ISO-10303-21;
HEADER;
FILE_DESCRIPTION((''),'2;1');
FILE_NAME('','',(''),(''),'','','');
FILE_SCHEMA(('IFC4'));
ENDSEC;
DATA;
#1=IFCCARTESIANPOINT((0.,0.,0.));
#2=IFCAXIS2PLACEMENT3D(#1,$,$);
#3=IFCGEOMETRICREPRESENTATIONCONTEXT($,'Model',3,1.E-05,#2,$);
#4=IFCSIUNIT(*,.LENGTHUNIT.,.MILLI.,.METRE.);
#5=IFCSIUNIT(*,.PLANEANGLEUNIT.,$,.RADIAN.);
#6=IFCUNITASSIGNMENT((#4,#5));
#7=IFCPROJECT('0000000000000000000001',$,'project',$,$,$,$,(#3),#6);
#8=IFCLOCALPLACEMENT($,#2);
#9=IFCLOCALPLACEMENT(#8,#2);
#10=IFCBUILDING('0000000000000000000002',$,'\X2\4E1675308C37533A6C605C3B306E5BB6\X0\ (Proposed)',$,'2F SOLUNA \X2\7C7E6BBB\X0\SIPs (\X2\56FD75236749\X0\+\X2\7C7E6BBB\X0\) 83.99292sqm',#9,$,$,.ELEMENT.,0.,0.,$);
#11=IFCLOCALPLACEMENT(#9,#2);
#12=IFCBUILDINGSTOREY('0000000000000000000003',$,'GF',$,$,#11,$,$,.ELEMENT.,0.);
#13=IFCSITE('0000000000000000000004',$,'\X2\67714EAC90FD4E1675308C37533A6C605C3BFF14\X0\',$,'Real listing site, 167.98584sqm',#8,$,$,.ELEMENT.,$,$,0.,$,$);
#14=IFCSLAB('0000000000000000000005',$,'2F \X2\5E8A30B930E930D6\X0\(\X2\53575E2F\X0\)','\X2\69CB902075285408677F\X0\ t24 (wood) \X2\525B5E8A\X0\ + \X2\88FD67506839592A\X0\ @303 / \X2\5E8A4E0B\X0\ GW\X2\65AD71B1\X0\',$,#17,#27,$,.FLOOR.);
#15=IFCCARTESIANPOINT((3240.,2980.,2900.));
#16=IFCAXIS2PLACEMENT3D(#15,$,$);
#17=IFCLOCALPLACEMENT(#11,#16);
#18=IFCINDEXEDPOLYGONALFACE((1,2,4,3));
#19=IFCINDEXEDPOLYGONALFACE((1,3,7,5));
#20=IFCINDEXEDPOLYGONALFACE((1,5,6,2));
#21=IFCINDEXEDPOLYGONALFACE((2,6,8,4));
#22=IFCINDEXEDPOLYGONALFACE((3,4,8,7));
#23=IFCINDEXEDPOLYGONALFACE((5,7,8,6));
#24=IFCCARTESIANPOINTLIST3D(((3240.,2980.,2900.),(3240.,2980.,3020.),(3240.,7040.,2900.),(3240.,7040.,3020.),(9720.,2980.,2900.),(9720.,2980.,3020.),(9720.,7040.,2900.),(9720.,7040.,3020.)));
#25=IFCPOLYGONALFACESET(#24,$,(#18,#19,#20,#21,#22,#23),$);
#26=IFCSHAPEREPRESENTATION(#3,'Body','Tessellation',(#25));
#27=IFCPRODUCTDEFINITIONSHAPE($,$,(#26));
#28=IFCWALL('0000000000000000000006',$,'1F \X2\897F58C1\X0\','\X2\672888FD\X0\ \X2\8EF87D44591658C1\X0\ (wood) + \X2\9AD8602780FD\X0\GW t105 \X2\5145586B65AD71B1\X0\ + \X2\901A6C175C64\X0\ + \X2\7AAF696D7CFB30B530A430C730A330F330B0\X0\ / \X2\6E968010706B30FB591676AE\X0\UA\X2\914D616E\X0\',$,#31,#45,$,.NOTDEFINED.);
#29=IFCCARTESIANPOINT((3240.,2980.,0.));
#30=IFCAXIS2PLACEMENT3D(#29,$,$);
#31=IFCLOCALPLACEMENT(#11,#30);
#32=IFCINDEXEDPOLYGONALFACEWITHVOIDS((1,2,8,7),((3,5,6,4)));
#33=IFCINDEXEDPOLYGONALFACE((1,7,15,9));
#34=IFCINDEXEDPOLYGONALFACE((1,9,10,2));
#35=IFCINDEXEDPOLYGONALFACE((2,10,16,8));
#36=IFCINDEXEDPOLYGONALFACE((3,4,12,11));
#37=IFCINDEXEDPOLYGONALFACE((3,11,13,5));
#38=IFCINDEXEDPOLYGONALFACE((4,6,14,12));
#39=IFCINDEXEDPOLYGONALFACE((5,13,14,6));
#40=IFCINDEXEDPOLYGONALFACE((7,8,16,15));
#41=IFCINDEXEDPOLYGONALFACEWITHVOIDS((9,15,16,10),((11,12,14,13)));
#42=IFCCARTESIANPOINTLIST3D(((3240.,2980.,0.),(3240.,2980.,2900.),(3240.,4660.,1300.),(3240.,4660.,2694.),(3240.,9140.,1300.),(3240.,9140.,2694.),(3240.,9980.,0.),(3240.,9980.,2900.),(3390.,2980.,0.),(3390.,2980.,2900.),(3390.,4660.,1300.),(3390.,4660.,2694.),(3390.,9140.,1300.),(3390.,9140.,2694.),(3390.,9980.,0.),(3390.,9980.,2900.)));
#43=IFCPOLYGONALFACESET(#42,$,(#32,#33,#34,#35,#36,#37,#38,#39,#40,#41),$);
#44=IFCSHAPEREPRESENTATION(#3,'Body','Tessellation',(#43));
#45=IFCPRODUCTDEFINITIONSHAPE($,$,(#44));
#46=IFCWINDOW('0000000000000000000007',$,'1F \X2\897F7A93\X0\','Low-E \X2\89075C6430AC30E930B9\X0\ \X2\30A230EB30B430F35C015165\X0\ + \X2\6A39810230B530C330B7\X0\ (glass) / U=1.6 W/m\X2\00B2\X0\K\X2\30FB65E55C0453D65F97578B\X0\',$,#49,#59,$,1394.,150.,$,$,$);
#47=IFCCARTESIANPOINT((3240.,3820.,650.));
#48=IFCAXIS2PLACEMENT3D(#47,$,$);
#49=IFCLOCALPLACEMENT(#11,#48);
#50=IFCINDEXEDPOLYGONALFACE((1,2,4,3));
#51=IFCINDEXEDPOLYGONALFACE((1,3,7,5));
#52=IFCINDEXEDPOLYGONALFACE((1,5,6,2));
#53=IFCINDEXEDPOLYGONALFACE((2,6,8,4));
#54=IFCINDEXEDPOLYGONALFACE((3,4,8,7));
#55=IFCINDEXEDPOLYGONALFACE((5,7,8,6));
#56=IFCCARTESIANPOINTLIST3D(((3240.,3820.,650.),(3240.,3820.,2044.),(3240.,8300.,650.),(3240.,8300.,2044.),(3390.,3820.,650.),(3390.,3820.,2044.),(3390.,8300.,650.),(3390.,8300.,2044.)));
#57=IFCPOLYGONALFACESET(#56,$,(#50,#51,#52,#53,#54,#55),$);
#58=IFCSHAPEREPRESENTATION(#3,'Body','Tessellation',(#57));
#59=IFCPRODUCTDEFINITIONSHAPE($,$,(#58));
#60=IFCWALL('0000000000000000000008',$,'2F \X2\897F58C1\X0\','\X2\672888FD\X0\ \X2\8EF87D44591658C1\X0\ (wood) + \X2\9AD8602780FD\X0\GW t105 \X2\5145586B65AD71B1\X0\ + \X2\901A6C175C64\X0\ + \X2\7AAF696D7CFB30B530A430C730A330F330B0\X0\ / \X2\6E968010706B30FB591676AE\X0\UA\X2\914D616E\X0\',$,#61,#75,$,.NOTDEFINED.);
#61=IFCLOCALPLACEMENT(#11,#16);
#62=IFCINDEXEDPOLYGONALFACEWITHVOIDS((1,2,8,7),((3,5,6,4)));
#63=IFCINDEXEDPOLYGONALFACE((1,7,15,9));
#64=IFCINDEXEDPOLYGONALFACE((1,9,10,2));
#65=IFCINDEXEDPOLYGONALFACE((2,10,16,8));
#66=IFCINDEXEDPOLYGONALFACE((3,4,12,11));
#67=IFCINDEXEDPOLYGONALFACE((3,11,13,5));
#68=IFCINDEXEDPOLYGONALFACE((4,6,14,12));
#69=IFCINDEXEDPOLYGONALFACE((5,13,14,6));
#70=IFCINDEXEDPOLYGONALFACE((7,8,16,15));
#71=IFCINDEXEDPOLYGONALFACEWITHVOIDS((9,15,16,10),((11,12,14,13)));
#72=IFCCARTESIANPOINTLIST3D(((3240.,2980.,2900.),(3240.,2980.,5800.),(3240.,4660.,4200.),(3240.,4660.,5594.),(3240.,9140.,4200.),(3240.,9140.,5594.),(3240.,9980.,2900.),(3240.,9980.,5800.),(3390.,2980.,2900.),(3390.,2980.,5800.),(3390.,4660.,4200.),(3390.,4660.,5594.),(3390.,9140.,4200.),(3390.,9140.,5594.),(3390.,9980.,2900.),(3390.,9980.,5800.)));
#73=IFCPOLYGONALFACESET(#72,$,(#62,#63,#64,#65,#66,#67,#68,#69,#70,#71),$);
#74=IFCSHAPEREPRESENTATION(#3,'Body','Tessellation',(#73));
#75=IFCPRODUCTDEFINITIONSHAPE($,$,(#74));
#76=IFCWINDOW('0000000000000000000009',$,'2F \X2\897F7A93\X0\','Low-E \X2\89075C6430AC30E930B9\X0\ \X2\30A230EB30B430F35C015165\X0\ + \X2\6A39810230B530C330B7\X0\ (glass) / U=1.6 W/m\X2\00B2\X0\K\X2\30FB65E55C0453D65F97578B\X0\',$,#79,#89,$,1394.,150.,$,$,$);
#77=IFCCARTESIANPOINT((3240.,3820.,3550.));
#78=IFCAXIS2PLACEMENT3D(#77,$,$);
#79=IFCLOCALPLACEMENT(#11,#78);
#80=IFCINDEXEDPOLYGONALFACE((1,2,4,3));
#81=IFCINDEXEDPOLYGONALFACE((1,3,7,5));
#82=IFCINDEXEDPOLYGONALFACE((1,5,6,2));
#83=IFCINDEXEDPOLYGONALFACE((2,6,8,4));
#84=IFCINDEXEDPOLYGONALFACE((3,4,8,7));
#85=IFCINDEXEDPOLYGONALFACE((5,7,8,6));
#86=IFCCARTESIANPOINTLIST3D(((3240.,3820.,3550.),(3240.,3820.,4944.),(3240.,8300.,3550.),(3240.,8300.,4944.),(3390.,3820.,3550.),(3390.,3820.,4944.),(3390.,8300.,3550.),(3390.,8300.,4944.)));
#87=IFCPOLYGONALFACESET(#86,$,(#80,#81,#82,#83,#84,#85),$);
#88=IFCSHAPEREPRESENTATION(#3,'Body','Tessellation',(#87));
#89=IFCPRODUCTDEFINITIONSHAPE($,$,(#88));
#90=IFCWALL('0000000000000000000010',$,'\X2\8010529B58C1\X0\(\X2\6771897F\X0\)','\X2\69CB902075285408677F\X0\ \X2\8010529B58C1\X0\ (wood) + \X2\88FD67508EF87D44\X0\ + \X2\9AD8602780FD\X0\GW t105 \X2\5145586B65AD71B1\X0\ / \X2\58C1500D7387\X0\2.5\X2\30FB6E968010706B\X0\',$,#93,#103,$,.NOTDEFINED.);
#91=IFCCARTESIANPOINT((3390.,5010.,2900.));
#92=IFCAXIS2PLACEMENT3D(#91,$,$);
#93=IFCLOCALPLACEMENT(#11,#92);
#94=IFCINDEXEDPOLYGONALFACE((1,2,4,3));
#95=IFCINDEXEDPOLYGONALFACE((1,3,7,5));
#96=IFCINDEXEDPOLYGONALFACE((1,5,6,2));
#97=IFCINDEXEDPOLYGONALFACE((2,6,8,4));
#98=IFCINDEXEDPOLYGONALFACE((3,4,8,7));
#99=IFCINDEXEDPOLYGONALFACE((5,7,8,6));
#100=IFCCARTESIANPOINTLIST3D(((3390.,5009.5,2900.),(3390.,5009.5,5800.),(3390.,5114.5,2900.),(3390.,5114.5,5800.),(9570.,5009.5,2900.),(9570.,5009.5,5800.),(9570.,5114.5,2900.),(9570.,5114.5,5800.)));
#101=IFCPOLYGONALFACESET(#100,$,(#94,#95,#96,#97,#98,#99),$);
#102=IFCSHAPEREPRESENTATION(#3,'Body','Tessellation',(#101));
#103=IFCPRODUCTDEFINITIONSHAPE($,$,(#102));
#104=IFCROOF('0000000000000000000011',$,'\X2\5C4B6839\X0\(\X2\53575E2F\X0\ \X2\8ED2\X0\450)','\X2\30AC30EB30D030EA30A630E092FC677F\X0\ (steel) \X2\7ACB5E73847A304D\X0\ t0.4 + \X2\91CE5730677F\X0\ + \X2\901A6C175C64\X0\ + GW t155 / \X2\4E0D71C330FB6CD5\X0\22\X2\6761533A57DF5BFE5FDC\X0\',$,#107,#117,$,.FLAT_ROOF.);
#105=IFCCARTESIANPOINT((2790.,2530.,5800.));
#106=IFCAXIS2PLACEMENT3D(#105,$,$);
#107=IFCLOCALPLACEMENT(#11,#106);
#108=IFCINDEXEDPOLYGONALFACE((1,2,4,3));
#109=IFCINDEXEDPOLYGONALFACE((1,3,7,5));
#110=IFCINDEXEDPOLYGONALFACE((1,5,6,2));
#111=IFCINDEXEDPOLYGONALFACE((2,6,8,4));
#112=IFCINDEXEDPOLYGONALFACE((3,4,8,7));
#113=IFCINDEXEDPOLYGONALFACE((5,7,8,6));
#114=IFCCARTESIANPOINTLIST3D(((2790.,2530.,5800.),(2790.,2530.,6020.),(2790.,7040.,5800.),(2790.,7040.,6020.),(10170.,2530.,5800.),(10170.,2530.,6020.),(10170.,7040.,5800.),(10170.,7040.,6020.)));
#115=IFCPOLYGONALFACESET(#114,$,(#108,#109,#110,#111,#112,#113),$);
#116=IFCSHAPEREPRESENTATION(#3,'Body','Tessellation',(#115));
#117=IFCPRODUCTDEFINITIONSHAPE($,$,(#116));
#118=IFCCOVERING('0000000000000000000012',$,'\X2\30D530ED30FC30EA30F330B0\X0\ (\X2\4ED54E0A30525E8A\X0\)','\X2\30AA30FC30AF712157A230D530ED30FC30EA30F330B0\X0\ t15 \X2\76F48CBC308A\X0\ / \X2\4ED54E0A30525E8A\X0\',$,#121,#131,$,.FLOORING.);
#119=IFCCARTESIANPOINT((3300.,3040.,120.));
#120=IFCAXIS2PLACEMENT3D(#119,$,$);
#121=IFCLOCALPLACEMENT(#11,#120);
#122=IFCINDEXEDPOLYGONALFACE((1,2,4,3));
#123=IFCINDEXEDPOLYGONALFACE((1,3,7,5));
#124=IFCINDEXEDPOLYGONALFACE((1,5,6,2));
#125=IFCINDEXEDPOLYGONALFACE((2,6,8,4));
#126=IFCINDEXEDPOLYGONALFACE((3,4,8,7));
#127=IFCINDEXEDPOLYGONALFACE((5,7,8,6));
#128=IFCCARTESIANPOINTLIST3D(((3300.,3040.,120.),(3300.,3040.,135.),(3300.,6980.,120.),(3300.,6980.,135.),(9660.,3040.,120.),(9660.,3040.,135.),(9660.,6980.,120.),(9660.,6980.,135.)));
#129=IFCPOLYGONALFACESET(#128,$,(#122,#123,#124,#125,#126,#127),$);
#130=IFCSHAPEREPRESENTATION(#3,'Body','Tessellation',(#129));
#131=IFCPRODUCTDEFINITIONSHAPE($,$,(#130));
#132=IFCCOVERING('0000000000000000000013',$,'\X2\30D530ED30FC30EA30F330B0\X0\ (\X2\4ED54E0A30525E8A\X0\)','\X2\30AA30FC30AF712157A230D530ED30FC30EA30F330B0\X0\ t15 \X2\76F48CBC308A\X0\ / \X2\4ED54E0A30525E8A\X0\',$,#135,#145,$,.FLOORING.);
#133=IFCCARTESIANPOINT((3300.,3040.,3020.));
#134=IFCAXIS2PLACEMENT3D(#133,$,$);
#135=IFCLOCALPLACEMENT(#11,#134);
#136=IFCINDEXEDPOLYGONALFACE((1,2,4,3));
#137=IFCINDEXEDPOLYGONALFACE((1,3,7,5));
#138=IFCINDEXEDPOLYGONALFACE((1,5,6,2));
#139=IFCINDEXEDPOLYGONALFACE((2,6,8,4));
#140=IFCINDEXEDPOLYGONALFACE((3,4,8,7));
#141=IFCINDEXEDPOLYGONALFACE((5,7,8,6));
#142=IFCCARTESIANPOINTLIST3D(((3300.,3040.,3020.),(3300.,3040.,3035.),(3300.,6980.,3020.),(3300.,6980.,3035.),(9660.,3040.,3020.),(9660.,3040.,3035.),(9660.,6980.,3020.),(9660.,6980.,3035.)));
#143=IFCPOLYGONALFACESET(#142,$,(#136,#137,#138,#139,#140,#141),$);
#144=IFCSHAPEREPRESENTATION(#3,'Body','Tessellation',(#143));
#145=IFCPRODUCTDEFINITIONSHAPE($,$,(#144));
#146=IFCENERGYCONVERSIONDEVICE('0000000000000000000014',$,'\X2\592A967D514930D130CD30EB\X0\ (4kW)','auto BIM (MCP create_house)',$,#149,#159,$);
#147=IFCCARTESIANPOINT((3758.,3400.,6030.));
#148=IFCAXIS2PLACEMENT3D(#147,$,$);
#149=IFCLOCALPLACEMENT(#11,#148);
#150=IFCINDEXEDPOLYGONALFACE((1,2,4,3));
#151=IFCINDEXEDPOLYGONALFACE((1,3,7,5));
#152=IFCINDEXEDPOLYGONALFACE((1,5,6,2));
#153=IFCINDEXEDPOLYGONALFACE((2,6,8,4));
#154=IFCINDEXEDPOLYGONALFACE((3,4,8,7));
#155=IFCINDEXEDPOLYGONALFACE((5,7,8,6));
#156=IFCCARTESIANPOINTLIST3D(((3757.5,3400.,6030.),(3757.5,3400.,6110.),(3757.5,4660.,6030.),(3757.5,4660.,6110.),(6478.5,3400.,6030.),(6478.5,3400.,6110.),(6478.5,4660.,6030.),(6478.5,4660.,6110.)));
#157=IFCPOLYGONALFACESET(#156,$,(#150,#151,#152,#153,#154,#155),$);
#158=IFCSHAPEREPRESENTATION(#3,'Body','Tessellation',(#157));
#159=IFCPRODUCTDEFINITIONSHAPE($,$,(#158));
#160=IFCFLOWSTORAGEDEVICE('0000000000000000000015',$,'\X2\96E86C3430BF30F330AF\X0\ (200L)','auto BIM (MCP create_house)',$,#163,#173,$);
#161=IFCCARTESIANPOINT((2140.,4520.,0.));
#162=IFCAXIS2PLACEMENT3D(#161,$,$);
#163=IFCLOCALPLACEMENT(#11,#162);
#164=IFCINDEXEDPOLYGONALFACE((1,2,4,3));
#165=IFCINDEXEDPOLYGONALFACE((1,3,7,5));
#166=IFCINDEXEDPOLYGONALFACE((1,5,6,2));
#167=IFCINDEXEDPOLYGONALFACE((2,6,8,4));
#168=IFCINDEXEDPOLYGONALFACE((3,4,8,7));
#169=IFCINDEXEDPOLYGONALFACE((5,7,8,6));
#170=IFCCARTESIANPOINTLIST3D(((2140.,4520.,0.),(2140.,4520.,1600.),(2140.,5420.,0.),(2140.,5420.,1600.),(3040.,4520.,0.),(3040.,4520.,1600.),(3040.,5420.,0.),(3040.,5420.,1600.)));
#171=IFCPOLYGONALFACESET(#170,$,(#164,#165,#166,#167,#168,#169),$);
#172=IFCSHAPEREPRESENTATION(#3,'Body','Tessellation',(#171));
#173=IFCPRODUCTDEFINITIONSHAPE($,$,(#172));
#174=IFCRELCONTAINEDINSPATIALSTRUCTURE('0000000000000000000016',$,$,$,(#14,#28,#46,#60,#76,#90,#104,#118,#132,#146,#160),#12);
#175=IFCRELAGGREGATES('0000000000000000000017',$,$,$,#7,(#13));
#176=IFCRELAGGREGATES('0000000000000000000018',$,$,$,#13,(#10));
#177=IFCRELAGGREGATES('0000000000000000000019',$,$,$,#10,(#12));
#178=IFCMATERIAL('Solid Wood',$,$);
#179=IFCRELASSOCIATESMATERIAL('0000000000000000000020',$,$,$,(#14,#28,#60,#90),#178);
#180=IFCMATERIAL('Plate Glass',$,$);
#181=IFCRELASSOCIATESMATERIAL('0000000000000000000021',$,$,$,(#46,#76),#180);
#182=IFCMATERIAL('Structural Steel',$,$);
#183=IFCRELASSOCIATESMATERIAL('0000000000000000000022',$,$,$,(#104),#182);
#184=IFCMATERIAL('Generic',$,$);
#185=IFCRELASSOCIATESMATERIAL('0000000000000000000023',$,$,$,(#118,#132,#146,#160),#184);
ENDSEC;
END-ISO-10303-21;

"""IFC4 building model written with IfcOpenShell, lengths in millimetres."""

from ifc_helpers import new_model, si_unit, frame, frame_2d, origin, place, context, project, spatial, rectangle, extrude, material, element, fill, save


model = new_model("IFC4")

# Units and contexts
model_context = context("Model", 3, precision=1e-05, world=origin())
ifc_project = project(units=[si_unit("LENGTHUNIT", "METRE", prefix="MILLI"), si_unit("PLANEANGLEUNIT", "RADIAN")], contexts=[model_context])

# Site, building, storey
site_placement = place(None, origin())
site = spatial("IfcSite", under=ifc_project, at=site_placement, Name="東京都世田谷区池尻４", ObjectType="Real listing site, 167.98584sqm", CompositionType="ELEMENT", RefElevation=0.0)
building_placement = place(site_placement, origin())
building = spatial("IfcBuilding", under=site, at=building_placement, Name="世田谷区池尻の家 (Proposed)", ObjectType="2F SOLUNA 籾殻SIPs (国産杉+籾殻) 83.99292sqm", CompositionType="ELEMENT", ElevationOfRefHeight=0.0, ElevationOfTerrain=0.0)
storey_placement = place(building_placement, origin())
storey = spatial("IfcBuildingStorey", under=building, at=storey_placement, Name="GF", CompositionType="ELEMENT", Elevation=0.0)

# Slab
ifc_material_1 = material(Name="Solid Wood")
slab_1_placement = place(storey_placement, frame((3240.0, 2980.0, 2900.0)))
element("IfcSlab", 1, at=slab_1_placement, inside=storey, material=ifc_material_1, Name="2F 床スラブ(南帯)", Description="構造用合板 t24 (wood) 剛床 + 製材根太 @303 / 床下 GW断熱", PredefinedType="FLOOR", context=model_context, shape_type="SweptSolid", body=[
    extrude(rectangle(XDim=6480.0, YDim=4060.0, at=frame_2d((3240.0, 2030.0))), frame((3240.0, 2980.0, 2900.0)), (0.0, 0.0, 1.0), 120.0),
])

# Shared definitions
ifc_material_2 = material(Name="Plate Glass")

# Wall, opening, window
wall_1_placement = place(storey_placement, frame((3240.0, 2980.0, 0.0)))
wall_1 = element("IfcWall", 2, at=wall_1_placement, inside=storey, material=ifc_material_1, Name="1F 西壁", Description="木製 軸組外壁 (wood) + 高性能GW t105 充填断熱 + 通気層 + 窯業系サイディング / 準耐火・外皮UA配慮", PredefinedType="NOTDEFINED", context=model_context, shape_type="SweptSolid", body=[
    extrude(rectangle(XDim=150.0, YDim=7000.0, at=frame_2d((75.0, 3500.0))), frame((3240.0, 2980.0, 0.0)), (0.0, 0.0, 1.0), 2900.0),
])
opening_1_placement = place(storey_placement, frame((3240.0, 3820.0, 650.0)))
opening_1 = element("IfcOpeningElement", 3, at=opening_1_placement, cuts=wall_1, PredefinedType="NOTDEFINED", context=model_context, shape_type="SweptSolid", body=[
    extrude(rectangle(XDim=150.0, YDim=4480.0, at=frame_2d((75.0, 2240.0))), frame((3240.0, 3820.0, 650.0)), (0.0, 0.0, 1.0), 1394.0),
])
window_1_placement = place(storey_placement, frame((3240.0, 3820.0, 650.0)))
window_1 = element("IfcWindow", 4, at=window_1_placement, inside=storey, material=ifc_material_2, Name="1F 西窓", Description="Low-E 複層ガラス アルゴン封入 + 樹脂サッシ (glass) / U=1.6 W/m²K・日射取得型", OverallHeight=1394.0, OverallWidth=150.0, context=model_context, shape_type="SweptSolid", body=[
    extrude(rectangle(XDim=150.0, YDim=4480.0, at=frame_2d((75.0, 2240.0))), frame((3240.0, 3820.0, 650.0)), (0.0, 0.0, 1.0), 1394.0),
])
fill(opening_1, window_1)

# Wall, opening, window
wall_2_placement = place(storey_placement, frame((3240.0, 2980.0, 2900.0)))
wall_2 = element("IfcWall", 5, at=wall_2_placement, inside=storey, material=ifc_material_1, Name="2F 西壁", Description="木製 軸組外壁 (wood) + 高性能GW t105 充填断熱 + 通気層 + 窯業系サイディング / 準耐火・外皮UA配慮", PredefinedType="NOTDEFINED", context=model_context, shape_type="SweptSolid", body=[
    extrude(rectangle(XDim=150.0, YDim=7000.0, at=frame_2d((75.0, 3500.0))), frame((3240.0, 2980.0, 2900.0)), (0.0, 0.0, 1.0), 2900.0),
])
opening_2_placement = place(storey_placement, frame((3240.0, 3820.0, 3550.0)))
opening_2 = element("IfcOpeningElement", 6, at=opening_2_placement, cuts=wall_2, PredefinedType="NOTDEFINED", context=model_context, shape_type="SweptSolid", body=[
    extrude(rectangle(XDim=150.0, YDim=4480.0, at=frame_2d((75.0, 2240.0))), frame((3240.0, 3820.0, 3550.0)), (0.0, 0.0, 1.0), 1394.0),
])
window_2_placement = place(storey_placement, frame((3240.0, 3820.0, 3550.0)))
window_2 = element("IfcWindow", 7, at=window_2_placement, inside=storey, material=ifc_material_2, Name="2F 西窓", Description="Low-E 複層ガラス アルゴン封入 + 樹脂サッシ (glass) / U=1.6 W/m²K・日射取得型", OverallHeight=1394.0, OverallWidth=150.0, context=model_context, shape_type="SweptSolid", body=[
    extrude(rectangle(XDim=150.0, YDim=4480.0, at=frame_2d((75.0, 2240.0))), frame((3240.0, 3820.0, 3550.0)), (0.0, 0.0, 1.0), 1394.0),
])
fill(opening_2, window_2)

# Wall
wall_3_placement = place(storey_placement, frame((3390.0, 5010.0, 2900.0)))
element("IfcWall", 8, at=wall_3_placement, inside=storey, material=ifc_material_1, Name="耐力壁(東西)", Description="構造用合板 耐力壁 (wood) + 製材軸組 + 高性能GW t105 充填断熱 / 壁倍率2.5・準耐火", PredefinedType="NOTDEFINED", context=model_context, shape_type="SweptSolid", body=[
    extrude(rectangle(XDim=6180.0, YDim=105.0, at=frame_2d((3090.0, 52.0))), frame((3390.0, 5010.0, 2900.0)), (0.0, 0.0, 1.0), 2900.0),
])

# Roof
ifc_material_3 = material(Name="Structural Steel")
for number, where, name in (
    (9, (2790.0, 2530.0, 5800.0), "屋根(南帯 軒450)"),
):
    element("IfcRoof", number, at=place(storey_placement, frame(where)), inside=storey, material=ifc_material_3, Name=name, Description="ガルバリウム鋼板 (steel) 立平葺き t0.4 + 野地板 + 通気層 + GW t155 / 不燃・法22条区域対応", PredefinedType="FLAT_ROOF", context=model_context, shape_type="SweptSolid", body=[
        extrude(rectangle(XDim=7380.0, YDim=4510.0, at=frame_2d((3690.0, 2255.0))), frame((2790.0, 2530.0, 5800.0)), (0.0, 0.0, 1.0), 220.0),
    ])

# Coverings
ifc_material_4 = material(Name="Generic")
covering_1_placement = place(storey_placement, frame((3300.0, 3040.0, 120.0)))
element("IfcCovering", 10, at=covering_1_placement, inside=storey, material=ifc_material_4, Name="フローリング (仕上げ床)", Description="オーク無垢フローリング t15 直貼り / 仕上げ床", PredefinedType="FLOORING", context=model_context, shape_type="SweptSolid", body=[
    extrude(rectangle(XDim=6360.0, YDim=3940.0, at=frame_2d((3180.0, 1970.0))), frame((3300.0, 3040.0, 120.0)), (0.0, 0.0, 1.0), 15.0),
])
covering_2_placement = place(storey_placement, frame((3300.0, 3040.0, 3020.0)))
element("IfcCovering", 11, at=covering_2_placement, inside=storey, material=ifc_material_4, Name="フローリング (仕上げ床)", Description="オーク無垢フローリング t15 直貼り / 仕上げ床", PredefinedType="FLOORING", context=model_context, shape_type="SweptSolid", body=[
    extrude(rectangle(XDim=6360.0, YDim=3940.0, at=frame_2d((3180.0, 1970.0))), frame((3300.0, 3040.0, 3020.0)), (0.0, 0.0, 1.0), 15.0),
])

# Energy conversion device
energy_conversion_device_placement = place(storey_placement, frame((3758.0, 3400.0, 6030.0)))
element("IfcEnergyConversionDevice", 12, at=energy_conversion_device_placement, inside=storey, material=ifc_material_4, Name="太陽光パネル (4kW)", Description="auto BIM (MCP create_house)", context=model_context, shape_type="SweptSolid", body=[
    extrude(rectangle(XDim=2721.0, YDim=1260.0, at=frame_2d((1360.0, 630.0))), frame((3758.0, 3400.0, 6030.0)), (0.0, 0.0, 1.0), 80.0),
])

# Flow storage device
flow_storage_device_placement = place(storey_placement, frame((2140.0, 4520.0, 0.0)))
element("IfcFlowStorageDevice", 13, at=flow_storage_device_placement, inside=storey, material=ifc_material_4, Name="雨水タンク (200L)", Description="auto BIM (MCP create_house)", context=model_context, shape_type="SweptSolid", body=[
    extrude(rectangle(XDim=900.0, YDim=900.0, at=frame_2d((450.0, 450.0))), frame((2140.0, 4520.0, 0.0)), (0.0, 0.0, 1.0), 1600.0),
])

save(model, "model.ifc")
